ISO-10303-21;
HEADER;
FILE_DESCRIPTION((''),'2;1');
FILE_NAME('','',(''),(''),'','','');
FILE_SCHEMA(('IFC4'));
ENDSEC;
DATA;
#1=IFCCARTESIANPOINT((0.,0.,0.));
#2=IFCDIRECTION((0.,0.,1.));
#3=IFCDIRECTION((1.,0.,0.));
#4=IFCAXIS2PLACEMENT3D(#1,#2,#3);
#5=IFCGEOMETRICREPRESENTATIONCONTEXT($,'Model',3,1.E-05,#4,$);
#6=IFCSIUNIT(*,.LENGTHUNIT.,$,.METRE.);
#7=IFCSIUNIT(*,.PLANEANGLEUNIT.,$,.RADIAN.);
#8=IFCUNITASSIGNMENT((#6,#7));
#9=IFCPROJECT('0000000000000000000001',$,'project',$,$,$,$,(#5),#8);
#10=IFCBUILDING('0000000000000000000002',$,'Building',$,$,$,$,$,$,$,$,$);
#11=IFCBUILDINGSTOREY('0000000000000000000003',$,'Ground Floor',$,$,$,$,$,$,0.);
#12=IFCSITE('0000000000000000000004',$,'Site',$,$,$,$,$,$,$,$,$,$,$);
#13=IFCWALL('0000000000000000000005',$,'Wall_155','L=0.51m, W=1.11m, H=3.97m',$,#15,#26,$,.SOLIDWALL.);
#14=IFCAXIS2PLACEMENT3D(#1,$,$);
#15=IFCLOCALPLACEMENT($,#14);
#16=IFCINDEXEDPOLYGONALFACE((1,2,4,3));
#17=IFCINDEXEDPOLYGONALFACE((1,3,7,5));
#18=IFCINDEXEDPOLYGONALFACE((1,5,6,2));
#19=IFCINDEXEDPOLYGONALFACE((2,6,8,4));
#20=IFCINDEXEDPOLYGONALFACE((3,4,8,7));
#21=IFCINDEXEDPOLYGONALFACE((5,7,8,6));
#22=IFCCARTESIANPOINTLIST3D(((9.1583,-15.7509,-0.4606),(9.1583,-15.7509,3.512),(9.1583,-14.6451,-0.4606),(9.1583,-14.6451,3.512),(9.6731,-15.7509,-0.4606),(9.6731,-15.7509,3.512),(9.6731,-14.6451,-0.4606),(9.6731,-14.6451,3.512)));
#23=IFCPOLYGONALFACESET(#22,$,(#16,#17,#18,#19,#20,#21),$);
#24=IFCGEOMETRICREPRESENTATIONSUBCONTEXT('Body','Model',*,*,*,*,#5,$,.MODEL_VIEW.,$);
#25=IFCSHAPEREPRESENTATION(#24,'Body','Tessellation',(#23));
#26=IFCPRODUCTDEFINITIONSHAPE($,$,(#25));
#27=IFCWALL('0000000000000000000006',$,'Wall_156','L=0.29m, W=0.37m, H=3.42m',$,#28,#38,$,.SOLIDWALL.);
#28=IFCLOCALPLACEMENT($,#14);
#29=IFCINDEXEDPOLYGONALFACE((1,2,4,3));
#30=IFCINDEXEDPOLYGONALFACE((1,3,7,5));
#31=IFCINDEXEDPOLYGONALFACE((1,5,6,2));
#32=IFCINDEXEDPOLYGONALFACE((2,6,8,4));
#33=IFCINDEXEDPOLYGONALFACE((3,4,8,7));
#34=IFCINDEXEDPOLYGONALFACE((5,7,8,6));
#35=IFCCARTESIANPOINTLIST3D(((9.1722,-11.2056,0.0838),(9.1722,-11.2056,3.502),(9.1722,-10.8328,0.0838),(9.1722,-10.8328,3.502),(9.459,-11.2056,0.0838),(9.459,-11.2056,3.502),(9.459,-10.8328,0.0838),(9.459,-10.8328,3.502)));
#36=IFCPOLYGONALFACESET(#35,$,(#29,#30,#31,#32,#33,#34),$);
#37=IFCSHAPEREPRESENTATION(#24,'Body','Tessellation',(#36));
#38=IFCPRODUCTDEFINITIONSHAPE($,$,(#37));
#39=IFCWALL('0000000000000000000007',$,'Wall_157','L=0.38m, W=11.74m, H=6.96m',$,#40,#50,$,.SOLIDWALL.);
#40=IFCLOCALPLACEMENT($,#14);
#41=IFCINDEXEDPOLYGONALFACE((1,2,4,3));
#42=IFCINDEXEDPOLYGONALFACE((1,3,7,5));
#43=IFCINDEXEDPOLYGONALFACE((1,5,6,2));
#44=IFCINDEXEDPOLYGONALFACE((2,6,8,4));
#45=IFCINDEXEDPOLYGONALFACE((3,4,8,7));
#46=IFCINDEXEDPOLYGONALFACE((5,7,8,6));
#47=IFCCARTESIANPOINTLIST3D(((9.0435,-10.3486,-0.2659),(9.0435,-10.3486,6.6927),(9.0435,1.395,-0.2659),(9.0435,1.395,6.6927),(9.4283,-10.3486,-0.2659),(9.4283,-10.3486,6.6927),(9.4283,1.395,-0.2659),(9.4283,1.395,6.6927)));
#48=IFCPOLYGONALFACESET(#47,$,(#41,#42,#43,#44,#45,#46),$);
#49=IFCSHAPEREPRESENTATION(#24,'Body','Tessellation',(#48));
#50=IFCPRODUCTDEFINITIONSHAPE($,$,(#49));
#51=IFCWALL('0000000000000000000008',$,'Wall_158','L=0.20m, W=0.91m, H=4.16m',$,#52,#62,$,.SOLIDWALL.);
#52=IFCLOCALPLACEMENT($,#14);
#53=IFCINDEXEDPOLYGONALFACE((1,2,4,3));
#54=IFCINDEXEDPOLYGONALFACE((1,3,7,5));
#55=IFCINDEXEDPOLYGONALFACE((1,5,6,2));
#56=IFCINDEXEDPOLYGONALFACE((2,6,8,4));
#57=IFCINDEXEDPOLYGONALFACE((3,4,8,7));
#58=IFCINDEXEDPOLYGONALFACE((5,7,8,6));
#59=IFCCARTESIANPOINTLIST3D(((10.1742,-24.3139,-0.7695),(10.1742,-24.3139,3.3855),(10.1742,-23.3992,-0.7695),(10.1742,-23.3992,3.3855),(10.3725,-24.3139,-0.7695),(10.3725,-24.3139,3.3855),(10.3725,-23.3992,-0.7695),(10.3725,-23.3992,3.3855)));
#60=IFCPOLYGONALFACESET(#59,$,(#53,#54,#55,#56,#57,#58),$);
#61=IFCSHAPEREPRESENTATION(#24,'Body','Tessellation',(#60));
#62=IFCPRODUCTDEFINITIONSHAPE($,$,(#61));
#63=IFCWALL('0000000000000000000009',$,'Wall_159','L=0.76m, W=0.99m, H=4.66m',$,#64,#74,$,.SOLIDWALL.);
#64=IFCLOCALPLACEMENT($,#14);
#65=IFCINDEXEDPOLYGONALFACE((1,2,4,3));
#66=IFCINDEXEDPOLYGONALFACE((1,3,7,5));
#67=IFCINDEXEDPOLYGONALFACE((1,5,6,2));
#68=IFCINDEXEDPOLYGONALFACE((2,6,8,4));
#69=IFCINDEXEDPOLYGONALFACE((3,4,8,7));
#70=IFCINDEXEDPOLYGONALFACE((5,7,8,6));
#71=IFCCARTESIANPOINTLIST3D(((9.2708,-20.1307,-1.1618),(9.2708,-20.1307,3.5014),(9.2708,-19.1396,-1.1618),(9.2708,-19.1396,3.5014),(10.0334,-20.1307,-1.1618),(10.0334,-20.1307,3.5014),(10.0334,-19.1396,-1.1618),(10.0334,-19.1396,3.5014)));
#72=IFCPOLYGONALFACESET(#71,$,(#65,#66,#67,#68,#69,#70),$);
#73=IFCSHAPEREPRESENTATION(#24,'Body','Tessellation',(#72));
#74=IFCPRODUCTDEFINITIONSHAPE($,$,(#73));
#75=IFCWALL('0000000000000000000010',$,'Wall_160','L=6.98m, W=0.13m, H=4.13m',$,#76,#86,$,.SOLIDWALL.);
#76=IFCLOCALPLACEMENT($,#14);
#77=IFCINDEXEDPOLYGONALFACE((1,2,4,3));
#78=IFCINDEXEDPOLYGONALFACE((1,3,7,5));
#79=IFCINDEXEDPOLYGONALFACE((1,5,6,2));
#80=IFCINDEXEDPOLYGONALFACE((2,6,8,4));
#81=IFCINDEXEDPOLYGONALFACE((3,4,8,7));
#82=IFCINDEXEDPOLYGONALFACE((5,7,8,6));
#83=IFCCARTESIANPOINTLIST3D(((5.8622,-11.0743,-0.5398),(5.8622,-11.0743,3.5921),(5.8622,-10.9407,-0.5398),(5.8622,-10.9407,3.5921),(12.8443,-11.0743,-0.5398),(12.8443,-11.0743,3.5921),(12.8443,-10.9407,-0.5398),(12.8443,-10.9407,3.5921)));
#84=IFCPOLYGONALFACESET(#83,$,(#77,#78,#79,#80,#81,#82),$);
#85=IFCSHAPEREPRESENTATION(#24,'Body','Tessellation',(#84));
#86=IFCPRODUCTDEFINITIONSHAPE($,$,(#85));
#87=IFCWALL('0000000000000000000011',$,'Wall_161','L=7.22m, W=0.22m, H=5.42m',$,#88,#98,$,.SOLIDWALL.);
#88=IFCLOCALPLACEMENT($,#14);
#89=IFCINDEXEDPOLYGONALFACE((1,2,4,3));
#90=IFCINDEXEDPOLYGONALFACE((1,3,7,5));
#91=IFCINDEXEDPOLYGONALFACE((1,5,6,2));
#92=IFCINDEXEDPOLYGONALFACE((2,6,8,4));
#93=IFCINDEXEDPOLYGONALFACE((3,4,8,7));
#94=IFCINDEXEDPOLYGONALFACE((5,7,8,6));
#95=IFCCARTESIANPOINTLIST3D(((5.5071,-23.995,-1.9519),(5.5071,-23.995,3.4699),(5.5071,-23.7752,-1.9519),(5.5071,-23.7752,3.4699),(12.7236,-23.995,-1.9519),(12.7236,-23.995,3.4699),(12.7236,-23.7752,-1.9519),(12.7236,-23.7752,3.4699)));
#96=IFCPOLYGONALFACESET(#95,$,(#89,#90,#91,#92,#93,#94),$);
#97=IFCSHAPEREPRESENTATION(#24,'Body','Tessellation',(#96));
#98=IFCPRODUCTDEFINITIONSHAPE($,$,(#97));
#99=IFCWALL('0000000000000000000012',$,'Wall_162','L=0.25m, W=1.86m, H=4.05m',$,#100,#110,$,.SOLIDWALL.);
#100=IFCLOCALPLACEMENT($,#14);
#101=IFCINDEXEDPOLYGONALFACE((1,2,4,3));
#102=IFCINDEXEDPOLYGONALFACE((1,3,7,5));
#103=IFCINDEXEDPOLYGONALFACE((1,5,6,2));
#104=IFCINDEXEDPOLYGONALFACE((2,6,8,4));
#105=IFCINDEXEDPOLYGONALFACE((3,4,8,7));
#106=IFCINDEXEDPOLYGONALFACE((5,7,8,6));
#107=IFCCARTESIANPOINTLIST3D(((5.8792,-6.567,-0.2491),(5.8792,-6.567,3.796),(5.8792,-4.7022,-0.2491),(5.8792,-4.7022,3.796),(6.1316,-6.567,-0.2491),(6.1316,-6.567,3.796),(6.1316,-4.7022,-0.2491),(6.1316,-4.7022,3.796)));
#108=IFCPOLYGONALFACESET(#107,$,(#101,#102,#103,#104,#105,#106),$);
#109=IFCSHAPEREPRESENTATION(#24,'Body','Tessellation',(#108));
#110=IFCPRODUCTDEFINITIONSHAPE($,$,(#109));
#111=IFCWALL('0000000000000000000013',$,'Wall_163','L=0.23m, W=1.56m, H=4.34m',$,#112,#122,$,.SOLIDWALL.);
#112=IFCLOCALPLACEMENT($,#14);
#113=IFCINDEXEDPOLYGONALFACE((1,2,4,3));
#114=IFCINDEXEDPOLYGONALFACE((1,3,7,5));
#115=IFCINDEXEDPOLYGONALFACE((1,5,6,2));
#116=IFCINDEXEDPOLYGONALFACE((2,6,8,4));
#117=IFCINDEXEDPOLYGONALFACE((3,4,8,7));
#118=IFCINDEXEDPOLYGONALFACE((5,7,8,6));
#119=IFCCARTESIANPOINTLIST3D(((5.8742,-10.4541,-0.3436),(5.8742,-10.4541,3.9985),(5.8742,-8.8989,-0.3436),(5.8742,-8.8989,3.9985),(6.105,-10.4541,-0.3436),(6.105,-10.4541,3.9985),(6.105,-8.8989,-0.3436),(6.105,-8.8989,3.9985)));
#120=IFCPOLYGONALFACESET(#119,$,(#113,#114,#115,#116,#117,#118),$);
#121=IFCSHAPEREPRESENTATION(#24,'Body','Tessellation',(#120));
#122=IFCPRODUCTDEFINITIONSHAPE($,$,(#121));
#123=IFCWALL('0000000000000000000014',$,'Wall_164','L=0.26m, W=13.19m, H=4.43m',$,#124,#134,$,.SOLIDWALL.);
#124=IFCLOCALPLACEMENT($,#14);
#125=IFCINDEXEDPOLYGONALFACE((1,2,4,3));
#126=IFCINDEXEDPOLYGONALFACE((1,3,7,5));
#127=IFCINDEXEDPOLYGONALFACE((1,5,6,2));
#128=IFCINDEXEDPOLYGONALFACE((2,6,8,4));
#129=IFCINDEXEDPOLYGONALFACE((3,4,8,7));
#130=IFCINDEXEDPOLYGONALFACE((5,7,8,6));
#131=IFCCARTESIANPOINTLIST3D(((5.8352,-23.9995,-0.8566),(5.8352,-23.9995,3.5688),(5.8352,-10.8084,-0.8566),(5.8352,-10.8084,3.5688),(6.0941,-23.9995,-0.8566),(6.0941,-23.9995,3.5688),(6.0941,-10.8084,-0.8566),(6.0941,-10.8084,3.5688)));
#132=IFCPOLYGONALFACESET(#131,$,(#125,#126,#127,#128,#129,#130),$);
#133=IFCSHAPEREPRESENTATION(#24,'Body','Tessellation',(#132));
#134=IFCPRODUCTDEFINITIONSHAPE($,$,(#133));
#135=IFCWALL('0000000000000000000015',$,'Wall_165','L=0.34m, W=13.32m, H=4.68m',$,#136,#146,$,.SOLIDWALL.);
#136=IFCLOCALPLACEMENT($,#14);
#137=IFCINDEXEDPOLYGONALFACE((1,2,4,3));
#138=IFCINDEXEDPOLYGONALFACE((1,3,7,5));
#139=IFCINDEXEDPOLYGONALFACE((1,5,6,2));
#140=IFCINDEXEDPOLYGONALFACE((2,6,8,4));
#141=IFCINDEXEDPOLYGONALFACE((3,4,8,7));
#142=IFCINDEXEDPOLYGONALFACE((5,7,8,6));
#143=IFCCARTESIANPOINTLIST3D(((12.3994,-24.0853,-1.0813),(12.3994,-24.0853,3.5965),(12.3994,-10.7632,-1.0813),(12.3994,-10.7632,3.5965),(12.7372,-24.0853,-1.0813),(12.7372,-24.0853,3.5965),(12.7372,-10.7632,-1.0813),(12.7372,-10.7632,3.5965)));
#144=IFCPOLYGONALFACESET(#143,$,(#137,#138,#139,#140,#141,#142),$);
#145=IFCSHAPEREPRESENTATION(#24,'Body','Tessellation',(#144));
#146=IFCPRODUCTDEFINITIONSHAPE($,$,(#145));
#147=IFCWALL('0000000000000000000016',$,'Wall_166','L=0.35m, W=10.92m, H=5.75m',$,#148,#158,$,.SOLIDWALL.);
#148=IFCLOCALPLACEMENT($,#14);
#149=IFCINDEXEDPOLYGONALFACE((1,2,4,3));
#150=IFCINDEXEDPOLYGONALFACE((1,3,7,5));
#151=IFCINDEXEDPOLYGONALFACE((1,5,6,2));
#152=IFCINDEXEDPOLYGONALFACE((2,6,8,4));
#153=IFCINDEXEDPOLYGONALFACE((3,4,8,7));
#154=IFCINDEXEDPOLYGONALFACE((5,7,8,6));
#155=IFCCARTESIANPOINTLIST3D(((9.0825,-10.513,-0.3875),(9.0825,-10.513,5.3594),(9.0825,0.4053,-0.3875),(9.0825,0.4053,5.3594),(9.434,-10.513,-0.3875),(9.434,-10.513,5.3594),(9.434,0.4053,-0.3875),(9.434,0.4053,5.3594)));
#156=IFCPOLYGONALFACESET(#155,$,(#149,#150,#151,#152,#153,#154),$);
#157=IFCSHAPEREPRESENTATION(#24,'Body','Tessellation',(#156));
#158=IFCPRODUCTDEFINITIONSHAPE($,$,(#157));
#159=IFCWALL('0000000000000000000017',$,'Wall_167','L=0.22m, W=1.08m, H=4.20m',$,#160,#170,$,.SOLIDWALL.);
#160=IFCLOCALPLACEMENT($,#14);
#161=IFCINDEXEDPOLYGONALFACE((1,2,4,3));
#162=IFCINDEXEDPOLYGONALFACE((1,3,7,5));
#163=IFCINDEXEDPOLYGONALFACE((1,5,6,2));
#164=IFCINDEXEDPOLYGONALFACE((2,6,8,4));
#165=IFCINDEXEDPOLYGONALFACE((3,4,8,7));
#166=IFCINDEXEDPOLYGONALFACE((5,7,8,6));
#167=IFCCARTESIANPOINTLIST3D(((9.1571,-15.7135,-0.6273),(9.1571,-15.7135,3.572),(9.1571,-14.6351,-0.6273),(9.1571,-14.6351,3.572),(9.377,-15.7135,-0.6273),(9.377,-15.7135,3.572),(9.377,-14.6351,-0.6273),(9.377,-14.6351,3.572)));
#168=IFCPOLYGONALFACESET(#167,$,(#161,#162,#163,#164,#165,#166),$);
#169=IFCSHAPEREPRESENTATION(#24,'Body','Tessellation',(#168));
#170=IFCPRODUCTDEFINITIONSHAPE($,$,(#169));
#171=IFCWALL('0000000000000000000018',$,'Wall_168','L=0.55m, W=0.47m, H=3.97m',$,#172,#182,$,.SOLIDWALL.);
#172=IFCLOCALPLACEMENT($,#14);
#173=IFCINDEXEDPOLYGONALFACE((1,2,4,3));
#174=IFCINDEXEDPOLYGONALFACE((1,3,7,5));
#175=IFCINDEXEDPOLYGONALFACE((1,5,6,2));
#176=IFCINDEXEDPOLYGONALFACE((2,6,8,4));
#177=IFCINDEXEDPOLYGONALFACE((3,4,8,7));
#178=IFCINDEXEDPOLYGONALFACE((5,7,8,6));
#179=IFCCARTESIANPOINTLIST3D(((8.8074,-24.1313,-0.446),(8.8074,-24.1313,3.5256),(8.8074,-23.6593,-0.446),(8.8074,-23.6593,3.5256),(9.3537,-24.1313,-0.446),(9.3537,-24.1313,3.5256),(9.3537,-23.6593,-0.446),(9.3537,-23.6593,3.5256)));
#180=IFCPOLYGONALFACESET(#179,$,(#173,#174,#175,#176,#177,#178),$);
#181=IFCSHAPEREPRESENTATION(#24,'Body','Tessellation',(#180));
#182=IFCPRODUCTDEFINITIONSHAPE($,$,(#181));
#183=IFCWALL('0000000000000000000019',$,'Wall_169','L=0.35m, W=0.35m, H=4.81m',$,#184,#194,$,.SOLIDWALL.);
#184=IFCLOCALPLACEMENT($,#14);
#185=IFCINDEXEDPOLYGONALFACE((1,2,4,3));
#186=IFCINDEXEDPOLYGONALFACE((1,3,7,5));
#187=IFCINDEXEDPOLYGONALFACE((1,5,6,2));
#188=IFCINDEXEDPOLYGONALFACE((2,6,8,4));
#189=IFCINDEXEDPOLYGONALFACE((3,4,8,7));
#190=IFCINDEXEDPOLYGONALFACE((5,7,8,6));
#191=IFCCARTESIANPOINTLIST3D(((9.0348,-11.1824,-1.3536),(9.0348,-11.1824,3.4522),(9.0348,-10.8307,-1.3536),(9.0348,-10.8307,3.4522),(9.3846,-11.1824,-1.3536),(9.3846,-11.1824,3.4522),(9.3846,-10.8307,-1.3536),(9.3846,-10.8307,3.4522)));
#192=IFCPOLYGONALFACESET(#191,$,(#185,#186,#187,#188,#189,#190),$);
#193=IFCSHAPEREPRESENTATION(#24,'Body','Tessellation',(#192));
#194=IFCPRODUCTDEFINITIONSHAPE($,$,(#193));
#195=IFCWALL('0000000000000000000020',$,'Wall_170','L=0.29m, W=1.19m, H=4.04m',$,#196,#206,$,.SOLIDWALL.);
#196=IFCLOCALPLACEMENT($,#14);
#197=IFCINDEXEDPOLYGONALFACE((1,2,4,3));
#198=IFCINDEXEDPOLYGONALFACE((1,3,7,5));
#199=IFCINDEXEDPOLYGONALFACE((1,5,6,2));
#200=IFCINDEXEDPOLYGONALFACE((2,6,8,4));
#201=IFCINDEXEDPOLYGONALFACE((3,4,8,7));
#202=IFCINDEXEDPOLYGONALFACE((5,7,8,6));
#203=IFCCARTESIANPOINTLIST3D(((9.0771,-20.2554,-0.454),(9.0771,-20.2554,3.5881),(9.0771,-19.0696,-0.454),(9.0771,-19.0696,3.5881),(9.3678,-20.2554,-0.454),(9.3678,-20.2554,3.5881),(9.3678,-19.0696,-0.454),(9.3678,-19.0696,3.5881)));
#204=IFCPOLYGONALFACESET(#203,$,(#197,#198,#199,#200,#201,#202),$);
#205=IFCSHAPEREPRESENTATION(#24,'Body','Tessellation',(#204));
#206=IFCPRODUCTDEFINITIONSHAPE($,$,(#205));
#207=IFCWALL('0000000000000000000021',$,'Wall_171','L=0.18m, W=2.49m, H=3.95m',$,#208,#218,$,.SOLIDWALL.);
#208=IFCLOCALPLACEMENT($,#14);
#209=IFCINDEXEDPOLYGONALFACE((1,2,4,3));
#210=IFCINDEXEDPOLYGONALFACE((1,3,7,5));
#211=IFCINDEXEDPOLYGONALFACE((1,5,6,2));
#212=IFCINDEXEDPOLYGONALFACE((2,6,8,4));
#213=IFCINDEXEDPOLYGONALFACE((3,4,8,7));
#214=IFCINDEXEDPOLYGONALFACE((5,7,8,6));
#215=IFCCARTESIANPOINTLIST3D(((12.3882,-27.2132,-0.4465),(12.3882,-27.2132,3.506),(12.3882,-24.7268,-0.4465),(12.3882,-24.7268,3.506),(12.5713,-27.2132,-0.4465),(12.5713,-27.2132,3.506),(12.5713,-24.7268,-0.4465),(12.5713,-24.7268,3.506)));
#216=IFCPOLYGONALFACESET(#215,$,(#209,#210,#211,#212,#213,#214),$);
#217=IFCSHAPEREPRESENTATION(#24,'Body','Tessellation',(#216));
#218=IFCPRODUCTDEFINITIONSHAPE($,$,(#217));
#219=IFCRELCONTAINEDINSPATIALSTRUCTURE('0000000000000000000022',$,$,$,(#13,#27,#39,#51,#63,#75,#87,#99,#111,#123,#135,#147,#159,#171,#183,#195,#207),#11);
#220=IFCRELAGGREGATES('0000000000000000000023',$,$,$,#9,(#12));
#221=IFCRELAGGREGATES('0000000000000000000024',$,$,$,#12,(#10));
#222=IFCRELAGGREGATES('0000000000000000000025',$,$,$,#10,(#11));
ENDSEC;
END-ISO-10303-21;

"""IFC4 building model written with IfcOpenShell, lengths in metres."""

from ifc_helpers import new_model, si_unit, frame, origin_with_axes, origin_2d, context, subcontext, project, spatial, rectangle, extrude, element, save


model = new_model("IFC4")

# Units and contexts
model_context = context("Model", 3, precision=1e-05, world=origin_with_axes())
body_context = subcontext(model_context, "Body", "Model", "MODEL_VIEW")
ifc_project = project(units=[si_unit("LENGTHUNIT", "METRE"), si_unit("PLANEANGLEUNIT", "RADIAN")], contexts=[model_context])

# Site, building, storey
site = spatial("IfcSite", under=ifc_project, Name="Site")
building = spatial("IfcBuilding", under=site, Name="Building")
storey = spatial("IfcBuildingStorey", under=building, Name="Ground Floor", Elevation=0.0)

# Walls
element("IfcWall", 1, inside=storey, Name="Wall_155", Description="L=0.51m, W=1.11m, H=3.97m", PredefinedType="SOLIDWALL", context=body_context, shape_type="SweptSolid", body=[
    extrude(rectangle(XDim=0.5147, YDim=1.1058, at=origin_2d()), frame((9.4157, -15.198, -0.4606), z_axis=(0.0, 0.0, 1.0), x_axis=(1.0, 0.0, 0.0)), (0.0, 0.0, 1.0), 3.9726),
])
element("IfcWall", 2, inside=storey, Name="Wall_156", Description="L=0.29m, W=0.37m, H=3.42m", PredefinedType="SOLIDWALL", context=body_context, shape_type="SweptSolid", body=[
    extrude(rectangle(XDim=0.2869, YDim=0.3728, at=origin_2d()), frame((9.3156, -11.0192, 0.0838), z_axis=(0.0, 0.0, 1.0), x_axis=(1.0, 0.0, 0.0)), (0.0, 0.0, 1.0), 3.4182),
])
element("IfcWall", 3, inside=storey, Name="Wall_157", Description="L=0.38m, W=11.74m, H=6.96m", PredefinedType="SOLIDWALL", context=body_context, shape_type="SweptSolid", body=[
    extrude(rectangle(XDim=0.3848, YDim=11.7436, at=origin_2d()), frame((9.2359, -4.4768, -0.2659), z_axis=(0.0, 0.0, 1.0), x_axis=(1.0, 0.0, 0.0)), (0.0, 0.0, 1.0), 6.9586),
])
element("IfcWall", 4, inside=storey, Name="Wall_158", Description="L=0.20m, W=0.91m, H=4.16m", PredefinedType="SOLIDWALL", context=body_context, shape_type="SweptSolid", body=[
    extrude(rectangle(XDim=0.1983, YDim=0.9148, at=origin_2d()), frame((10.2733, -23.8565, -0.7695), z_axis=(0.0, 0.0, 1.0), x_axis=(1.0, 0.0, 0.0)), (0.0, 0.0, 1.0), 4.155),
])
element("IfcWall", 5, inside=storey, Name="Wall_159", Description="L=0.76m, W=0.99m, H=4.66m", PredefinedType="SOLIDWALL", context=body_context, shape_type="SweptSolid", body=[
    extrude(rectangle(XDim=0.7626, YDim=0.9911, at=origin_2d()), frame((9.6521, -19.6352, -1.1618), z_axis=(0.0, 0.0, 1.0), x_axis=(1.0, 0.0, 0.0)), (0.0, 0.0, 1.0), 4.6632),
])
element("IfcWall", 6, inside=storey, Name="Wall_160", Description="L=6.98m, W=0.13m, H=4.13m", PredefinedType="SOLIDWALL", context=body_context, shape_type="SweptSolid", body=[
    extrude(rectangle(XDim=6.9821, YDim=0.1337, at=origin_2d()), frame((9.3532, -11.0075, -0.5398), z_axis=(0.0, 0.0, 1.0), x_axis=(1.0, 0.0, 0.0)), (0.0, 0.0, 1.0), 4.132),
])
element("IfcWall", 7, inside=storey, Name="Wall_161", Description="L=7.22m, W=0.22m, H=5.42m", PredefinedType="SOLIDWALL", context=body_context, shape_type="SweptSolid", body=[
    extrude(rectangle(XDim=7.2165, YDim=0.2198, at=origin_2d()), frame((9.1153, -23.8851, -1.9519), z_axis=(0.0, 0.0, 1.0), x_axis=(1.0, 0.0, 0.0)), (0.0, 0.0, 1.0), 5.4218),
])
element("IfcWall", 8, inside=storey, Name="Wall_162", Description="L=0.25m, W=1.86m, H=4.05m", PredefinedType="SOLIDWALL", context=body_context, shape_type="SweptSolid", body=[
    extrude(rectangle(XDim=0.2524, YDim=1.8648, at=origin_2d()), frame((6.0054, -5.6346, -0.2491), z_axis=(0.0, 0.0, 1.0), x_axis=(1.0, 0.0, 0.0)), (0.0, 0.0, 1.0), 4.045),
])
element("IfcWall", 9, inside=storey, Name="Wall_163", Description="L=0.23m, W=1.56m, H=4.34m", PredefinedType="SOLIDWALL", context=body_context, shape_type="SweptSolid", body=[
    extrude(rectangle(XDim=0.2308, YDim=1.5552, at=origin_2d()), frame((5.9896, -9.6765, -0.3436), z_axis=(0.0, 0.0, 1.0), x_axis=(1.0, 0.0, 0.0)), (0.0, 0.0, 1.0), 4.3422),
])
element("IfcWall", 10, inside=storey, Name="Wall_164", Description="L=0.26m, W=13.19m, H=4.43m", PredefinedType="SOLIDWALL", context=body_context, shape_type="SweptSolid", body=[
    extrude(rectangle(XDim=0.2589, YDim=13.191, at=origin_2d()), frame((5.9647, -17.4039, -0.8566), z_axis=(0.0, 0.0, 1.0), x_axis=(1.0, 0.0, 0.0)), (0.0, 0.0, 1.0), 4.4254),
])
element("IfcWall", 11, inside=storey, Name="Wall_165", Description="L=0.34m, W=13.32m, H=4.68m", PredefinedType="SOLIDWALL", context=body_context, shape_type="SweptSolid", body=[
    extrude(rectangle(XDim=0.3377, YDim=13.3221, at=origin_2d()), frame((12.5683, -17.4243, -1.0813), z_axis=(0.0, 0.0, 1.0), x_axis=(1.0, 0.0, 0.0)), (0.0, 0.0, 1.0), 4.6778),
])
element("IfcWall", 12, inside=storey, Name="Wall_166", Description="L=0.35m, W=10.92m, H=5.75m", PredefinedType="SOLIDWALL", context=body_context, shape_type="SweptSolid", body=[
    extrude(rectangle(XDim=0.3516, YDim=10.9184, at=origin_2d()), frame((9.2583, -5.0538, -0.3875), z_axis=(0.0, 0.0, 1.0), x_axis=(1.0, 0.0, 0.0)), (0.0, 0.0, 1.0), 5.747),
])
element("IfcWall", 13, inside=storey, Name="Wall_167", Description="L=0.22m, W=1.08m, H=4.20m", PredefinedType="SOLIDWALL", context=body_context, shape_type="SweptSolid", body=[
    extrude(rectangle(XDim=0.2199, YDim=1.0784, at=origin_2d()), frame((9.267, -15.1743, -0.6273), z_axis=(0.0, 0.0, 1.0), x_axis=(1.0, 0.0, 0.0)), (0.0, 0.0, 1.0), 4.1993),
])
element("IfcWall", 14, inside=storey, Name="Wall_168", Description="L=0.55m, W=0.47m, H=3.97m", PredefinedType="SOLIDWALL", context=body_context, shape_type="SweptSolid", body=[
    extrude(rectangle(XDim=0.5463, YDim=0.472, at=origin_2d()), frame((9.0806, -23.8953, -0.446), z_axis=(0.0, 0.0, 1.0), x_axis=(1.0, 0.0, 0.0)), (0.0, 0.0, 1.0), 3.9716),
])
element("IfcWall", 15, inside=storey, Name="Wall_169", Description="L=0.35m, W=0.35m, H=4.81m", PredefinedType="SOLIDWALL", context=body_context, shape_type="SweptSolid", body=[
    extrude(rectangle(XDim=0.3497, YDim=0.3517, at=origin_2d()), frame((9.2097, -11.0066, -1.3536), z_axis=(0.0, 0.0, 1.0), x_axis=(1.0, 0.0, 0.0)), (0.0, 0.0, 1.0), 4.8058),
])
element("IfcWall", 16, inside=storey, Name="Wall_170", Description="L=0.29m, W=1.19m, H=4.04m", PredefinedType="SOLIDWALL", context=body_context, shape_type="SweptSolid", body=[
    extrude(rectangle(XDim=0.2907, YDim=1.1858, at=origin_2d()), frame((9.2224, -19.6625, -0.454), z_axis=(0.0, 0.0, 1.0), x_axis=(1.0, 0.0, 0.0)), (0.0, 0.0, 1.0), 4.0421),
])
element("IfcWall", 17, inside=storey, Name="Wall_171", Description="L=0.18m, W=2.49m, H=3.95m", PredefinedType="SOLIDWALL", context=body_context, shape_type="SweptSolid", body=[
    extrude(rectangle(XDim=0.1831, YDim=2.4865, at=origin_2d()), frame((12.4797, -25.97, -0.4465), z_axis=(0.0, 0.0, 1.0), x_axis=(1.0, 0.0, 0.0)), (0.0, 0.0, 1.0), 3.9525),
])

save(model, "model.ifc")
